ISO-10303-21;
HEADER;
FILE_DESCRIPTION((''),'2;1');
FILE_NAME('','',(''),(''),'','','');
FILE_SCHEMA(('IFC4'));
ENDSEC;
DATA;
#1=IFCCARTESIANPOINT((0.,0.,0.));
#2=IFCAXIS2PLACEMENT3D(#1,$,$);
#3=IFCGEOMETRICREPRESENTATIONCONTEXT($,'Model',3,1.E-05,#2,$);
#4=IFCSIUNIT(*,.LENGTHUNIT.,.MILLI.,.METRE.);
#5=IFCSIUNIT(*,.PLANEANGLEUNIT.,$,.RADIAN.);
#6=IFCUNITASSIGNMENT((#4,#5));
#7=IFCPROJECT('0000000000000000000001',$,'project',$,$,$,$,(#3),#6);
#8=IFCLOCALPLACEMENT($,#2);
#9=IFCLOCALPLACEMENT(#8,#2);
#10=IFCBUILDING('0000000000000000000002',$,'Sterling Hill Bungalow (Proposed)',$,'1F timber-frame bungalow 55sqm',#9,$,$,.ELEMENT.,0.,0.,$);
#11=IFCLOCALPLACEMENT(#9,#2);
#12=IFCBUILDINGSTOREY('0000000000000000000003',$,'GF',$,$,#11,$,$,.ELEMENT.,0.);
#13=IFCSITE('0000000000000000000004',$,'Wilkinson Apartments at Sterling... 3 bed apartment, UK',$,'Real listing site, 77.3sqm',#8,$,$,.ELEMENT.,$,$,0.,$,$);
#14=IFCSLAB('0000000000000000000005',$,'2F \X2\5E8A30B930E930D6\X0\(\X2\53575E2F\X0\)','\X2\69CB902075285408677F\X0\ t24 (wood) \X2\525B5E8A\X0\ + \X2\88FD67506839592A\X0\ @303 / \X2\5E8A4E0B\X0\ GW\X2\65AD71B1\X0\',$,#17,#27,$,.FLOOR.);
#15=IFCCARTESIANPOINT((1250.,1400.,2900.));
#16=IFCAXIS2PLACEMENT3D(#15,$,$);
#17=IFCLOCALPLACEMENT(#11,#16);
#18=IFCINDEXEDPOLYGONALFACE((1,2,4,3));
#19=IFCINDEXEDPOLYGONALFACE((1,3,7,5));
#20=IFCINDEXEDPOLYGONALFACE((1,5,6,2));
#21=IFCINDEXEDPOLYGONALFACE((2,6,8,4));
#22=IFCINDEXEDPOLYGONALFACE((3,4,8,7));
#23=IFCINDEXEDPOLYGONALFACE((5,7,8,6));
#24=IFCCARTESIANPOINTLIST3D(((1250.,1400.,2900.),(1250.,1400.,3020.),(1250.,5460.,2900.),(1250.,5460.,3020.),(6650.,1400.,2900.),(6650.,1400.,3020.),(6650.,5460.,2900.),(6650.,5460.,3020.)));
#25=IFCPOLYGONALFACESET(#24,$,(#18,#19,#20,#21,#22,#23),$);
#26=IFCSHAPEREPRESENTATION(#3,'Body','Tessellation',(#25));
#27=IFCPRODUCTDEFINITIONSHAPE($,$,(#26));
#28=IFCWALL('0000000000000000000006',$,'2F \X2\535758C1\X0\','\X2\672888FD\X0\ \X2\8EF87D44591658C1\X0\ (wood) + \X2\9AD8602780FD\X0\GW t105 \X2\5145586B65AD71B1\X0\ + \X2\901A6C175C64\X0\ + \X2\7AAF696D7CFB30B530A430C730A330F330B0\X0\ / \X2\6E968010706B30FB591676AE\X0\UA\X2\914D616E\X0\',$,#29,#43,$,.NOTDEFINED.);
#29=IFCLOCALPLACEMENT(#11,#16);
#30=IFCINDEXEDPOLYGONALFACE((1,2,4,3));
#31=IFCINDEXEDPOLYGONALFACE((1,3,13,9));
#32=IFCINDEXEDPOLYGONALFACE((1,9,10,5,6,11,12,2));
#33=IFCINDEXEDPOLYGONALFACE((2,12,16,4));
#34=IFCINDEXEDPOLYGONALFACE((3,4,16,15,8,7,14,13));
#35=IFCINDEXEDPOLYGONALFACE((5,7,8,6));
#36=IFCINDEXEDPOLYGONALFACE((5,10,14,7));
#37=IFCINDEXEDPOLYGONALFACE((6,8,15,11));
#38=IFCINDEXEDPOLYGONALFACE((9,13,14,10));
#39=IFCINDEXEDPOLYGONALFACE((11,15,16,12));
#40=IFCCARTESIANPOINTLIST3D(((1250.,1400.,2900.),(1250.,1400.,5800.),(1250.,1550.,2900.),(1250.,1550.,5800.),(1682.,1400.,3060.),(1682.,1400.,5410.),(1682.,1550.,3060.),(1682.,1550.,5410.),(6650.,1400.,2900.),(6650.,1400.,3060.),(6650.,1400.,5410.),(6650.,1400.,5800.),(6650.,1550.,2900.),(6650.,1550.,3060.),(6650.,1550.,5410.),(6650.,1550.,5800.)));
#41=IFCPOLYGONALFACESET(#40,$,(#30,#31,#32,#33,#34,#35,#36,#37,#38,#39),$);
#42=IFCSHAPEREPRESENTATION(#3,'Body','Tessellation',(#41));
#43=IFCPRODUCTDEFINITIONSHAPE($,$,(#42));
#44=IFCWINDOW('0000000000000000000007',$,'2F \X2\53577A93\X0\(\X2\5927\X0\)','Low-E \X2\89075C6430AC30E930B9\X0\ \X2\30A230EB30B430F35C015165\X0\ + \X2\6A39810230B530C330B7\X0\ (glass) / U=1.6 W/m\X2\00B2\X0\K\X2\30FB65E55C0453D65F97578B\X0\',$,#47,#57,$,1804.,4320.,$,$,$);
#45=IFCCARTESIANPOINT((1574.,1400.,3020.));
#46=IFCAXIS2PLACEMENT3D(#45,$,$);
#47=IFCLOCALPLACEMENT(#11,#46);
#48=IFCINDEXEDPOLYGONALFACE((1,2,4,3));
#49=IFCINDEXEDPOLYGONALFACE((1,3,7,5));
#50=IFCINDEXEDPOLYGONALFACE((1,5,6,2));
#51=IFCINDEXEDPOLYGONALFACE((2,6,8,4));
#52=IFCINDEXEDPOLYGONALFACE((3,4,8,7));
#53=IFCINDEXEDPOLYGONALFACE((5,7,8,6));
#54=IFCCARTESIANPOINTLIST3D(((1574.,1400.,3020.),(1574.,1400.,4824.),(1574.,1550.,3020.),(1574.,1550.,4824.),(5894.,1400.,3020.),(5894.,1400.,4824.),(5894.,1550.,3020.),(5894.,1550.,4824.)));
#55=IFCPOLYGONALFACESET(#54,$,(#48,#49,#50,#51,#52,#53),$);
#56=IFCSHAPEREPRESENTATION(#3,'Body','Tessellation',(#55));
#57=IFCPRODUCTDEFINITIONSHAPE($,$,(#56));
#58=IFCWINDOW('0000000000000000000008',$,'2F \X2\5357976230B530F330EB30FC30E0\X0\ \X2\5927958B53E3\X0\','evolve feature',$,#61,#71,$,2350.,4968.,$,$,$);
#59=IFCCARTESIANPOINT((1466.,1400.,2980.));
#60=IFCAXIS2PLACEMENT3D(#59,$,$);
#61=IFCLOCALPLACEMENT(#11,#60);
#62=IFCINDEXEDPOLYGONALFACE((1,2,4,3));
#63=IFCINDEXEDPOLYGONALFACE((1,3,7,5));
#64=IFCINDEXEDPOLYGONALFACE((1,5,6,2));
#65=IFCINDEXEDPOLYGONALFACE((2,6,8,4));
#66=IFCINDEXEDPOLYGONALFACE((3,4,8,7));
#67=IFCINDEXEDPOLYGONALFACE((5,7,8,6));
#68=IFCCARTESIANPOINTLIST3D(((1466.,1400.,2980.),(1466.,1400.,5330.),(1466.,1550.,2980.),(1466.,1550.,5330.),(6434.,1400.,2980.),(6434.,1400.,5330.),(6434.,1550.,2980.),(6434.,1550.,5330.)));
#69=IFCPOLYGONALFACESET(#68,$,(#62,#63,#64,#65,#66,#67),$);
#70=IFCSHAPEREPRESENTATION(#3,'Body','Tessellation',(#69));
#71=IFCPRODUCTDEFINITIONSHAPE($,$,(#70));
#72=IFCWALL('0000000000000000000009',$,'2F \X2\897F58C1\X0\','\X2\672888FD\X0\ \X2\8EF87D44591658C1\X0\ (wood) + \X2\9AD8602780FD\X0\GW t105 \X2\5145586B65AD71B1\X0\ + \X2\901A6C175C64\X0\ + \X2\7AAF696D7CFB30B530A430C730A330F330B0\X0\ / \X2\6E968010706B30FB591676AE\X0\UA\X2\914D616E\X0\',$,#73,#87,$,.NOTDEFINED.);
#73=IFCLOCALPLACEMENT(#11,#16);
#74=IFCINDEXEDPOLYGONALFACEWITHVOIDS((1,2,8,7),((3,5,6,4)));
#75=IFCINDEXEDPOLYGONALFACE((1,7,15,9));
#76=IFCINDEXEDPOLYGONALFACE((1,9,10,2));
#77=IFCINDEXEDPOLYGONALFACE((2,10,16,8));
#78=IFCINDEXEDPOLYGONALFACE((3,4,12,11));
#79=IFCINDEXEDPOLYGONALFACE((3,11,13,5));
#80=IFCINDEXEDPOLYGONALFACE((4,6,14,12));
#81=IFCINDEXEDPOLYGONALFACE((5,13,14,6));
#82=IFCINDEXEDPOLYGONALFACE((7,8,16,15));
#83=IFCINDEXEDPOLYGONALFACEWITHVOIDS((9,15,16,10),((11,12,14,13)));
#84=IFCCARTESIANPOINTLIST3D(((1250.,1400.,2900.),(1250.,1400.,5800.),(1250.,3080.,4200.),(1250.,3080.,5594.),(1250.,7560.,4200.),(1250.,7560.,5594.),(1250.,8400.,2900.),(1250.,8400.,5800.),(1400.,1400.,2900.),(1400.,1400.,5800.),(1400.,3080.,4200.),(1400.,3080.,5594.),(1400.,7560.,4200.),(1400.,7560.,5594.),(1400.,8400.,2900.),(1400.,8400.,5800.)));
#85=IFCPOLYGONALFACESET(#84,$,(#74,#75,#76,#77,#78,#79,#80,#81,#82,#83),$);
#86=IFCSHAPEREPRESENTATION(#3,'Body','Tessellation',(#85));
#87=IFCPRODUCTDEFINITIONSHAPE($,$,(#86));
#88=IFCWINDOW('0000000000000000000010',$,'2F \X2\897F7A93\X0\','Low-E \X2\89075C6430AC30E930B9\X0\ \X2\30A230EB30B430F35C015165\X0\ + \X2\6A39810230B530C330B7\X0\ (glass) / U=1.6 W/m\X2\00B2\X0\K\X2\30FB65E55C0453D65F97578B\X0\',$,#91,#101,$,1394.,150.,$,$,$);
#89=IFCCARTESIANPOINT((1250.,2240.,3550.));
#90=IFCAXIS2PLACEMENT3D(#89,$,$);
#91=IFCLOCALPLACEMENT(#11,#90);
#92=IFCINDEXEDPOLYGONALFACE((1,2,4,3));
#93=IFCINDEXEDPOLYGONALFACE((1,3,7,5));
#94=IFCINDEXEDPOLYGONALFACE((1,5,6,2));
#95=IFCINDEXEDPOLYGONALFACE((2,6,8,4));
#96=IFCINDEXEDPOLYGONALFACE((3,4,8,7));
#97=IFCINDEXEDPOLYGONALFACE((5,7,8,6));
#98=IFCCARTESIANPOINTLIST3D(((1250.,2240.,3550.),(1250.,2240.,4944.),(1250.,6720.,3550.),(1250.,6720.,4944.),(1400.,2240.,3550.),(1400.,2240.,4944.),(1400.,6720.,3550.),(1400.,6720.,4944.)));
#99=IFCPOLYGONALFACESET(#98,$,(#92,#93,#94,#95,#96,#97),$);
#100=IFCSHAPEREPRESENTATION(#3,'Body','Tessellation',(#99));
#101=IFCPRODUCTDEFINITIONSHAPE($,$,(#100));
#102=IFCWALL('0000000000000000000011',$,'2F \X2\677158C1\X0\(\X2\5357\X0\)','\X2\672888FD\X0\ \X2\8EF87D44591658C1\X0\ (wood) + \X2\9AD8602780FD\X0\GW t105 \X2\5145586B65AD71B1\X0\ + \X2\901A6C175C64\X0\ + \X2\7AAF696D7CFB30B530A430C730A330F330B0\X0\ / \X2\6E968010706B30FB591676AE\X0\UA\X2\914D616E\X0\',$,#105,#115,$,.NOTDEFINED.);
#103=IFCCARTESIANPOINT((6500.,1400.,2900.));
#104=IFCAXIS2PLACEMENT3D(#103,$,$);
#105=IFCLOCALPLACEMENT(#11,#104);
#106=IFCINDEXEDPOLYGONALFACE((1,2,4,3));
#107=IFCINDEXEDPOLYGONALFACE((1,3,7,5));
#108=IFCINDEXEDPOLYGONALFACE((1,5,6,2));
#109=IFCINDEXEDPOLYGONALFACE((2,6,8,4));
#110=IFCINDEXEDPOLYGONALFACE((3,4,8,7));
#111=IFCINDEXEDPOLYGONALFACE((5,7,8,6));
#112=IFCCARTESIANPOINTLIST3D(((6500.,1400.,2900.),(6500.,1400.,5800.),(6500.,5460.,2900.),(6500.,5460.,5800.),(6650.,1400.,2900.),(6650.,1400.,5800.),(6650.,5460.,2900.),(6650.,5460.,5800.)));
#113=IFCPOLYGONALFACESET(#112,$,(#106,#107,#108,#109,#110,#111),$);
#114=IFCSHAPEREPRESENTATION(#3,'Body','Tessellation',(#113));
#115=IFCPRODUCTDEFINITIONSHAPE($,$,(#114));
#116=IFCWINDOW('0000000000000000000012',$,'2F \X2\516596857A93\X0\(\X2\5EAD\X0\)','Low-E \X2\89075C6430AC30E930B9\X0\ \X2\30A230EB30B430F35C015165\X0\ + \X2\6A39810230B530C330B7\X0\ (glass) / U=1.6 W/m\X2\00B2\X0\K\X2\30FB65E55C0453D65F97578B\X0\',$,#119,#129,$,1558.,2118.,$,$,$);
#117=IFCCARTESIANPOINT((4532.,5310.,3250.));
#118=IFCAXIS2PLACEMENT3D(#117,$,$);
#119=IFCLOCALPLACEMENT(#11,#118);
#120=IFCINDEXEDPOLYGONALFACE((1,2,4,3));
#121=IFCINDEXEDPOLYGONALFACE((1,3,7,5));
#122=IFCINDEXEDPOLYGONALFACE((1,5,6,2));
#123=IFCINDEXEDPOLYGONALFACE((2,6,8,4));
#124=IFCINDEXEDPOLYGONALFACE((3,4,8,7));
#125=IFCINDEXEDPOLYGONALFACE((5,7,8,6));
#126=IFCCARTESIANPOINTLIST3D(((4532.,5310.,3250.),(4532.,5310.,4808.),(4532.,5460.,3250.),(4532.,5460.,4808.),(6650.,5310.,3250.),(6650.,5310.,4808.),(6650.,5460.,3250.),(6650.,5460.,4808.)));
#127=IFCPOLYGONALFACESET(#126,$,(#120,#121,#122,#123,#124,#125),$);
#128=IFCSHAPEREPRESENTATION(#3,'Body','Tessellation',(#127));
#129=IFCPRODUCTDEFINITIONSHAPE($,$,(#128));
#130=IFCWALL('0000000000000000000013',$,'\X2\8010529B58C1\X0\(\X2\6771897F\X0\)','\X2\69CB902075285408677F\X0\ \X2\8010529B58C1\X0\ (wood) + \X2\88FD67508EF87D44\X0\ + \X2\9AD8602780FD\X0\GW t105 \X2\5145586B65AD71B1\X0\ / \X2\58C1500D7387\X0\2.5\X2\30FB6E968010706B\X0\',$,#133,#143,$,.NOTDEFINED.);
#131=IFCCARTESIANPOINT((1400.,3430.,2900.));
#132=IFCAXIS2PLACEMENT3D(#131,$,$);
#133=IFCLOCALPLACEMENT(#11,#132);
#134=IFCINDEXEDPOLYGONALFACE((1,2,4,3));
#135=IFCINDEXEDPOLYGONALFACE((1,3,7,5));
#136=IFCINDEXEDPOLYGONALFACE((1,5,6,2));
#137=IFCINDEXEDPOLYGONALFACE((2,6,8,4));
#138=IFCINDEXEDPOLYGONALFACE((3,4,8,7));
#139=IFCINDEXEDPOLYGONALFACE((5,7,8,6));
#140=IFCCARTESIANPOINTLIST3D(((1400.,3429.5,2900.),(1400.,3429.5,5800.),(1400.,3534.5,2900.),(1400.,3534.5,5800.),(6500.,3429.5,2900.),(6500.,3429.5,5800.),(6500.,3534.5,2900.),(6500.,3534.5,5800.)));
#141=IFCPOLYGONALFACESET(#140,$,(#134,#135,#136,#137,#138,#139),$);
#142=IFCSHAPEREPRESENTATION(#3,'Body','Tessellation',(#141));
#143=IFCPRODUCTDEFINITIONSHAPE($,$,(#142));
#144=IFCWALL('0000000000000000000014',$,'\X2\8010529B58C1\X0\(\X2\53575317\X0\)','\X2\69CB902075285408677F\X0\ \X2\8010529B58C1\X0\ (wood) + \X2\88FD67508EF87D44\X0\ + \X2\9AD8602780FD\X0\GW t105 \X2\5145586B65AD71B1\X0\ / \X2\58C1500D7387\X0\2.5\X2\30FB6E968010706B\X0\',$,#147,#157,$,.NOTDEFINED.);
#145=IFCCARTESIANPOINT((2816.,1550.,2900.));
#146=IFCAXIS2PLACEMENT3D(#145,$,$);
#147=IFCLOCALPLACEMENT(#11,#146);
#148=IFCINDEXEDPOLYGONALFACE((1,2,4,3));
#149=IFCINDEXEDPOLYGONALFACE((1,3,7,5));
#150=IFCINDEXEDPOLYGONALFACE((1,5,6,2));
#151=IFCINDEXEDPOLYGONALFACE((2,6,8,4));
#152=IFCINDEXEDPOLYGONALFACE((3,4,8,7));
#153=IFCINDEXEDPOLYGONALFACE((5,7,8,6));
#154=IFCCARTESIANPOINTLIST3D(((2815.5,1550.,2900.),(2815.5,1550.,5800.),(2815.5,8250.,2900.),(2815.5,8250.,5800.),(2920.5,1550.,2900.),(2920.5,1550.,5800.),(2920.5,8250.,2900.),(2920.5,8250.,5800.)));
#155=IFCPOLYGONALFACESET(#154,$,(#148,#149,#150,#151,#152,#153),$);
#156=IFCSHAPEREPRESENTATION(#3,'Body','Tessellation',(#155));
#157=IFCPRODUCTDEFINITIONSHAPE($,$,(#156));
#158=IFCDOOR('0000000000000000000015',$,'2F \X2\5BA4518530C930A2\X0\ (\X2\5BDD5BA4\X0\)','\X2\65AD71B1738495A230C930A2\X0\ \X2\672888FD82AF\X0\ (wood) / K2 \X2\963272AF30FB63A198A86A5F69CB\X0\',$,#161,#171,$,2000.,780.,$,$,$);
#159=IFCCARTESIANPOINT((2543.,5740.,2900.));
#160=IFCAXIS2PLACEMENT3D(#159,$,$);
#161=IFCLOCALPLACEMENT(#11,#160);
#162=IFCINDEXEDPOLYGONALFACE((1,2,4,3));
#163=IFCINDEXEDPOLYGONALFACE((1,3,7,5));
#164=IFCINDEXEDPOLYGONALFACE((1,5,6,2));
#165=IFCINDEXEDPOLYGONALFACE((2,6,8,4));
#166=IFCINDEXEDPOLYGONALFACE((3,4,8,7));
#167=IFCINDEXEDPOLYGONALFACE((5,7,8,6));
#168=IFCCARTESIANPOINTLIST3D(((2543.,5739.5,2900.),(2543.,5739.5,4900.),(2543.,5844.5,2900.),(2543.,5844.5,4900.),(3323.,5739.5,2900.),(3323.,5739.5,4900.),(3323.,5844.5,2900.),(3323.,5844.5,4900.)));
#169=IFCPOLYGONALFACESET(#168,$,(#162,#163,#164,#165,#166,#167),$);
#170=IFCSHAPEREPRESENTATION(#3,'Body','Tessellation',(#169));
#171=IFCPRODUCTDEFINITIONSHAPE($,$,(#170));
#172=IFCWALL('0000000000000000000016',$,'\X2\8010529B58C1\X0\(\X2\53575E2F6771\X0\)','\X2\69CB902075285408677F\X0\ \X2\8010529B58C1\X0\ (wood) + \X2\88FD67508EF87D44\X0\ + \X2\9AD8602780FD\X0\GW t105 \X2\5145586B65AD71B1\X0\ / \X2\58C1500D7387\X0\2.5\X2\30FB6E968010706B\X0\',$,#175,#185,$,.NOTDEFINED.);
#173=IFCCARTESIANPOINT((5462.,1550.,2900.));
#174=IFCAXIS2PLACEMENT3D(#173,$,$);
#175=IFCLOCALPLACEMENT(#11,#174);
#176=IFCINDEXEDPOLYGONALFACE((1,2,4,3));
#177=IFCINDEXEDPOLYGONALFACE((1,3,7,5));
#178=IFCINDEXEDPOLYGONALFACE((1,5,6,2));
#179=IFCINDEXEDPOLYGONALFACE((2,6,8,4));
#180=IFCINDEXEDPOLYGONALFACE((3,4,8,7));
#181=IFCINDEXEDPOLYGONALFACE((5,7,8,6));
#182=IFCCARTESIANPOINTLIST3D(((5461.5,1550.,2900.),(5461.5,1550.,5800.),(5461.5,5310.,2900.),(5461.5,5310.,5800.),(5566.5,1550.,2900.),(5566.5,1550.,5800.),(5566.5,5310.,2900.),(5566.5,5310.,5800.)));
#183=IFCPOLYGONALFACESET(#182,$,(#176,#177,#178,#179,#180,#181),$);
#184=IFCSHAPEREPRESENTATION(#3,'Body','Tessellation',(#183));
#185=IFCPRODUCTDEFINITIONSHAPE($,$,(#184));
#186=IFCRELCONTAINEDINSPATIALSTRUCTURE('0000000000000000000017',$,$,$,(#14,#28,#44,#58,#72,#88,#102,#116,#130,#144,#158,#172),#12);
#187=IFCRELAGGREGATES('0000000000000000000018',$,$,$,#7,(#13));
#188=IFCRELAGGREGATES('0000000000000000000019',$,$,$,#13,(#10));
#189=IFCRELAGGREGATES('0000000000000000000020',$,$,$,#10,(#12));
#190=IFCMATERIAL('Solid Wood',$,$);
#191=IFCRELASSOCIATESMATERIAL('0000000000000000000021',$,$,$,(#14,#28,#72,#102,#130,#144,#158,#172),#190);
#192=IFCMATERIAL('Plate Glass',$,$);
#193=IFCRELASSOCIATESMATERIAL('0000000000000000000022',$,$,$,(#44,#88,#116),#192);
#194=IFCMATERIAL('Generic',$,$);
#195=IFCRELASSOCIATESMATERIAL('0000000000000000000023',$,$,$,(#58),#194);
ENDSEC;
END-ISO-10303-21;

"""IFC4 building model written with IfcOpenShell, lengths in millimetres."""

from ifc_helpers import new_model, si_unit, frame, frame_2d, origin, place, context, project, spatial, rectangle, extrude, material, element, fill, save


model = new_model("IFC4")

# Units and contexts
model_context = context("Model", 3, precision=1e-05, world=origin())
ifc_project = project(units=[si_unit("LENGTHUNIT", "METRE", prefix="MILLI"), si_unit("PLANEANGLEUNIT", "RADIAN")], contexts=[model_context])

# Site, building, storey
site_placement = place(None, origin())
site = spatial("IfcSite", under=ifc_project, at=site_placement, Name="Wilkinson Apartments at Sterling... 3 bed apartment, UK", ObjectType="Real listing site, 77.3sqm", CompositionType="ELEMENT", RefElevation=0.0)
building_placement = place(site_placement, origin())
building = spatial("IfcBuilding", under=site, at=building_placement, Name="Sterling Hill Bungalow (Proposed)", ObjectType="1F timber-frame bungalow 55sqm", CompositionType="ELEMENT", ElevationOfRefHeight=0.0, ElevationOfTerrain=0.0)
storey_placement = place(building_placement, origin())
storey = spatial("IfcBuildingStorey", under=building, at=storey_placement, Name="GF", CompositionType="ELEMENT", Elevation=0.0)

# Slab
ifc_material_1 = material(Name="Solid Wood")
slab_placement = place(storey_placement, frame((1250.0, 1400.0, 2900.0)))
element("IfcSlab", 1, at=slab_placement, inside=storey, material=ifc_material_1, Name="2F 床スラブ(南帯)", Description="構造用合板 t24 (wood) 剛床 + 製材根太 @303 / 床下 GW断熱", PredefinedType="FLOOR", context=model_context, shape_type="SweptSolid", body=[
    extrude(rectangle(XDim=5400.0, YDim=4060.0, at=frame_2d((2700.0, 2030.0))), frame((1250.0, 1400.0, 2900.0)), (0.0, 0.0, 1.0), 120.0),
])

# Wall, openings, windows
wall_1_placement = place(storey_placement, frame((1250.0, 1400.0, 2900.0)))
wall_1 = element("IfcWall", 2, at=wall_1_placement, inside=storey, material=ifc_material_1, Name="2F 南壁", Description="木製 軸組外壁 (wood) + 高性能GW t105 充填断熱 + 通気層 + 窯業系サイディング / 準耐火・外皮UA配慮", PredefinedType="NOTDEFINED", context=model_context, shape_type="SweptSolid", body=[
    extrude(rectangle(XDim=5400.0, YDim=150.0, at=frame_2d((2700.0, 75.0))), frame((1250.0, 1400.0, 2900.0)), (0.0, 0.0, 1.0), 2900.0),
])
opening_1_placement = place(storey_placement, frame((1574.0, 1400.0, 3020.0)))
opening_1 = element("IfcOpeningElement", 3, at=opening_1_placement, cuts=wall_1, PredefinedType="NOTDEFINED", context=model_context, shape_type="SweptSolid", body=[
    extrude(rectangle(XDim=4320.0, YDim=150.0, at=frame_2d((2160.0, 75.0))), frame((1574.0, 1400.0, 3020.0)), (0.0, 0.0, 1.0), 1804.0),
])
opening_2_placement = place(storey_placement, frame((1466.0, 1400.0, 2980.0)))
opening_2 = element("IfcOpeningElement", 4, at=opening_2_placement, cuts=wall_1, PredefinedType="NOTDEFINED", context=model_context, shape_type="SweptSolid", body=[
    extrude(rectangle(XDim=4968.0, YDim=150.0, at=frame_2d((2484.0, 75.0))), frame((1466.0, 1400.0, 2980.0)), (0.0, 0.0, 1.0), 2350.0),
])
ifc_material_2 = material(Name="Plate Glass")
window_1_placement = place(storey_placement, frame((1574.0, 1400.0, 3020.0)))
window_1 = element("IfcWindow", 5, at=window_1_placement, inside=storey, material=ifc_material_2, Name="2F 南窓(大)", Description="Low-E 複層ガラス アルゴン封入 + 樹脂サッシ (glass) / U=1.6 W/m²K・日射取得型", OverallHeight=1804.0, OverallWidth=4320.0, context=model_context, shape_type="SweptSolid", body=[
    extrude(rectangle(XDim=4320.0, YDim=150.0, at=frame_2d((2160.0, 75.0))), frame((1574.0, 1400.0, 3020.0)), (0.0, 0.0, 1.0), 1804.0),
])
fill(opening_1, window_1)
ifc_material_3 = material(Name="Generic")
window_2_placement = place(storey_placement, frame((1466.0, 1400.0, 2980.0)))
window_2 = element("IfcWindow", 6, at=window_2_placement, inside=storey, material=ifc_material_3, Name="2F 南面サンルーム 大開口", Description="evolve feature", OverallHeight=2350.0, OverallWidth=4968.0, context=model_context, shape_type="SweptSolid", body=[
    extrude(rectangle(XDim=4968.0, YDim=150.0, at=frame_2d((2484.0, 75.0))), frame((1466.0, 1400.0, 2980.0)), (0.0, 0.0, 1.0), 2350.0),
])
fill(opening_2, window_2)

# Walls, openings, windows
wall_2_placement = place(storey_placement, frame((1250.0, 1400.0, 2900.0)))
wall_2 = element("IfcWall", 7, at=wall_2_placement, inside=storey, material=ifc_material_1, Name="2F 西壁", Description="木製 軸組外壁 (wood) + 高性能GW t105 充填断熱 + 通気層 + 窯業系サイディング / 準耐火・外皮UA配慮", PredefinedType="NOTDEFINED", context=model_context, shape_type="SweptSolid", body=[
    extrude(rectangle(XDim=150.0, YDim=7000.0, at=frame_2d((75.0, 3500.0))), frame((1250.0, 1400.0, 2900.0)), (0.0, 0.0, 1.0), 2900.0),
])
opening_3_placement = place(storey_placement, frame((1250.0, 2240.0, 3550.0)))
opening_3 = element("IfcOpeningElement", 8, at=opening_3_placement, cuts=wall_2, PredefinedType="NOTDEFINED", context=model_context, shape_type="SweptSolid", body=[
    extrude(rectangle(XDim=150.0, YDim=4480.0, at=frame_2d((75.0, 2240.0))), frame((1250.0, 2240.0, 3550.0)), (0.0, 0.0, 1.0), 1394.0),
])
window_3_placement = place(storey_placement, frame((1250.0, 2240.0, 3550.0)))
window_3 = element("IfcWindow", 9, at=window_3_placement, inside=storey, material=ifc_material_2, Name="2F 西窓", Description="Low-E 複層ガラス アルゴン封入 + 樹脂サッシ (glass) / U=1.6 W/m²K・日射取得型", OverallHeight=1394.0, OverallWidth=150.0, context=model_context, shape_type="SweptSolid", body=[
    extrude(rectangle(XDim=150.0, YDim=4480.0, at=frame_2d((75.0, 2240.0))), frame((1250.0, 2240.0, 3550.0)), (0.0, 0.0, 1.0), 1394.0),
])
fill(opening_3, window_3)
wall_3_placement = place(storey_placement, frame((6500.0, 1400.0, 2900.0)))
wall_3 = element("IfcWall", 10, at=wall_3_placement, inside=storey, material=ifc_material_1, Name="2F 東壁(南)", Description="木製 軸組外壁 (wood) + 高性能GW t105 充填断熱 + 通気層 + 窯業系サイディング / 準耐火・外皮UA配慮", PredefinedType="NOTDEFINED", context=model_context, shape_type="SweptSolid", body=[
    extrude(rectangle(XDim=150.0, YDim=4060.0, at=frame_2d((75.0, 2030.0))), frame((6500.0, 1400.0, 2900.0)), (0.0, 0.0, 1.0), 2900.0),
])
opening_4_placement = place(storey_placement, frame((4532.0, 5310.0, 3250.0)))
opening_4 = element("IfcOpeningElement", 11, at=opening_4_placement, cuts=wall_3, PredefinedType="NOTDEFINED", context=model_context, shape_type="SweptSolid", body=[
    extrude(rectangle(XDim=2118.0, YDim=150.0, at=frame_2d((1059.0, 75.0))), frame((4532.0, 5310.0, 3250.0)), (0.0, 0.0, 1.0), 1558.0),
])
window_4_placement = place(storey_placement, frame((4532.0, 5310.0, 3250.0)))
window_4 = element("IfcWindow", 12, at=window_4_placement, inside=storey, material=ifc_material_2, Name="2F 入隅窓(庭)", Description="Low-E 複層ガラス アルゴン封入 + 樹脂サッシ (glass) / U=1.6 W/m²K・日射取得型", OverallHeight=1558.0, OverallWidth=2118.0, context=model_context, shape_type="SweptSolid", body=[
    extrude(rectangle(XDim=2118.0, YDim=150.0, at=frame_2d((1059.0, 75.0))), frame((4532.0, 5310.0, 3250.0)), (0.0, 0.0, 1.0), 1558.0),
])
fill(opening_4, window_4)

# Wall
wall_4_placement = place(storey_placement, frame((1400.0, 3430.0, 2900.0)))
element("IfcWall", 13, at=wall_4_placement, inside=storey, material=ifc_material_1, Name="耐力壁(東西)", Description="構造用合板 耐力壁 (wood) + 製材軸組 + 高性能GW t105 充填断熱 / 壁倍率2.5・準耐火", PredefinedType="NOTDEFINED", context=model_context, shape_type="SweptSolid", body=[
    extrude(rectangle(XDim=5100.0, YDim=105.0, at=frame_2d((2550.0, 52.0))), frame((1400.0, 3430.0, 2900.0)), (0.0, 0.0, 1.0), 2900.0),
])

# Wall, opening, door
wall_5_placement = place(storey_placement, frame((2816.0, 1550.0, 2900.0)))
wall_5 = element("IfcWall", 14, at=wall_5_placement, inside=storey, material=ifc_material_1, Name="耐力壁(南北)", Description="構造用合板 耐力壁 (wood) + 製材軸組 + 高性能GW t105 充填断熱 / 壁倍率2.5・準耐火", PredefinedType="NOTDEFINED", context=model_context, shape_type="SweptSolid", body=[
    extrude(rectangle(XDim=105.0, YDim=6700.0, at=frame_2d((52.0, 3350.0))), frame((2816.0, 1550.0, 2900.0)), (0.0, 0.0, 1.0), 2900.0),
])
opening_5_placement = place(storey_placement, frame((2543.0, 5740.0, 2900.0)))
opening_5 = element("IfcOpeningElement", 15, at=opening_5_placement, cuts=wall_5, PredefinedType="NOTDEFINED", context=model_context, shape_type="SweptSolid", body=[
    extrude(rectangle(XDim=780.0, YDim=105.0, at=frame_2d((390.0, 52.0))), frame((2543.0, 5740.0, 2900.0)), (0.0, 0.0, 1.0), 2000.0),
])
door_placement = place(storey_placement, frame((2543.0, 5740.0, 2900.0)))
door = element("IfcDoor", 16, at=door_placement, inside=storey, material=ifc_material_1, Name="2F 室内ドア (寝室)", Description="断熱玄関ドア 木製芯 (wood) / K2 防犯・採風機構", OverallHeight=2000.0, OverallWidth=780.0, context=model_context, shape_type="SweptSolid", body=[
    extrude(rectangle(XDim=780.0, YDim=105.0, at=frame_2d((390.0, 52.0))), frame((2543.0, 5740.0, 2900.0)), (0.0, 0.0, 1.0), 2000.0),
])
fill(opening_5, door)

# Wall
wall_6_placement = place(storey_placement, frame((5462.0, 1550.0, 2900.0)))
element("IfcWall", 17, at=wall_6_placement, inside=storey, material=ifc_material_1, Name="耐力壁(南帯東)", Description="構造用合板 耐力壁 (wood) + 製材軸組 + 高性能GW t105 充填断熱 / 壁倍率2.5・準耐火", PredefinedType="NOTDEFINED", context=model_context, shape_type="SweptSolid", body=[
    extrude(rectangle(XDim=105.0, YDim=3760.0, at=frame_2d((52.0, 1880.0))), frame((5462.0, 1550.0, 2900.0)), (0.0, 0.0, 1.0), 2900.0),
])

save(model, "model.ifc")
